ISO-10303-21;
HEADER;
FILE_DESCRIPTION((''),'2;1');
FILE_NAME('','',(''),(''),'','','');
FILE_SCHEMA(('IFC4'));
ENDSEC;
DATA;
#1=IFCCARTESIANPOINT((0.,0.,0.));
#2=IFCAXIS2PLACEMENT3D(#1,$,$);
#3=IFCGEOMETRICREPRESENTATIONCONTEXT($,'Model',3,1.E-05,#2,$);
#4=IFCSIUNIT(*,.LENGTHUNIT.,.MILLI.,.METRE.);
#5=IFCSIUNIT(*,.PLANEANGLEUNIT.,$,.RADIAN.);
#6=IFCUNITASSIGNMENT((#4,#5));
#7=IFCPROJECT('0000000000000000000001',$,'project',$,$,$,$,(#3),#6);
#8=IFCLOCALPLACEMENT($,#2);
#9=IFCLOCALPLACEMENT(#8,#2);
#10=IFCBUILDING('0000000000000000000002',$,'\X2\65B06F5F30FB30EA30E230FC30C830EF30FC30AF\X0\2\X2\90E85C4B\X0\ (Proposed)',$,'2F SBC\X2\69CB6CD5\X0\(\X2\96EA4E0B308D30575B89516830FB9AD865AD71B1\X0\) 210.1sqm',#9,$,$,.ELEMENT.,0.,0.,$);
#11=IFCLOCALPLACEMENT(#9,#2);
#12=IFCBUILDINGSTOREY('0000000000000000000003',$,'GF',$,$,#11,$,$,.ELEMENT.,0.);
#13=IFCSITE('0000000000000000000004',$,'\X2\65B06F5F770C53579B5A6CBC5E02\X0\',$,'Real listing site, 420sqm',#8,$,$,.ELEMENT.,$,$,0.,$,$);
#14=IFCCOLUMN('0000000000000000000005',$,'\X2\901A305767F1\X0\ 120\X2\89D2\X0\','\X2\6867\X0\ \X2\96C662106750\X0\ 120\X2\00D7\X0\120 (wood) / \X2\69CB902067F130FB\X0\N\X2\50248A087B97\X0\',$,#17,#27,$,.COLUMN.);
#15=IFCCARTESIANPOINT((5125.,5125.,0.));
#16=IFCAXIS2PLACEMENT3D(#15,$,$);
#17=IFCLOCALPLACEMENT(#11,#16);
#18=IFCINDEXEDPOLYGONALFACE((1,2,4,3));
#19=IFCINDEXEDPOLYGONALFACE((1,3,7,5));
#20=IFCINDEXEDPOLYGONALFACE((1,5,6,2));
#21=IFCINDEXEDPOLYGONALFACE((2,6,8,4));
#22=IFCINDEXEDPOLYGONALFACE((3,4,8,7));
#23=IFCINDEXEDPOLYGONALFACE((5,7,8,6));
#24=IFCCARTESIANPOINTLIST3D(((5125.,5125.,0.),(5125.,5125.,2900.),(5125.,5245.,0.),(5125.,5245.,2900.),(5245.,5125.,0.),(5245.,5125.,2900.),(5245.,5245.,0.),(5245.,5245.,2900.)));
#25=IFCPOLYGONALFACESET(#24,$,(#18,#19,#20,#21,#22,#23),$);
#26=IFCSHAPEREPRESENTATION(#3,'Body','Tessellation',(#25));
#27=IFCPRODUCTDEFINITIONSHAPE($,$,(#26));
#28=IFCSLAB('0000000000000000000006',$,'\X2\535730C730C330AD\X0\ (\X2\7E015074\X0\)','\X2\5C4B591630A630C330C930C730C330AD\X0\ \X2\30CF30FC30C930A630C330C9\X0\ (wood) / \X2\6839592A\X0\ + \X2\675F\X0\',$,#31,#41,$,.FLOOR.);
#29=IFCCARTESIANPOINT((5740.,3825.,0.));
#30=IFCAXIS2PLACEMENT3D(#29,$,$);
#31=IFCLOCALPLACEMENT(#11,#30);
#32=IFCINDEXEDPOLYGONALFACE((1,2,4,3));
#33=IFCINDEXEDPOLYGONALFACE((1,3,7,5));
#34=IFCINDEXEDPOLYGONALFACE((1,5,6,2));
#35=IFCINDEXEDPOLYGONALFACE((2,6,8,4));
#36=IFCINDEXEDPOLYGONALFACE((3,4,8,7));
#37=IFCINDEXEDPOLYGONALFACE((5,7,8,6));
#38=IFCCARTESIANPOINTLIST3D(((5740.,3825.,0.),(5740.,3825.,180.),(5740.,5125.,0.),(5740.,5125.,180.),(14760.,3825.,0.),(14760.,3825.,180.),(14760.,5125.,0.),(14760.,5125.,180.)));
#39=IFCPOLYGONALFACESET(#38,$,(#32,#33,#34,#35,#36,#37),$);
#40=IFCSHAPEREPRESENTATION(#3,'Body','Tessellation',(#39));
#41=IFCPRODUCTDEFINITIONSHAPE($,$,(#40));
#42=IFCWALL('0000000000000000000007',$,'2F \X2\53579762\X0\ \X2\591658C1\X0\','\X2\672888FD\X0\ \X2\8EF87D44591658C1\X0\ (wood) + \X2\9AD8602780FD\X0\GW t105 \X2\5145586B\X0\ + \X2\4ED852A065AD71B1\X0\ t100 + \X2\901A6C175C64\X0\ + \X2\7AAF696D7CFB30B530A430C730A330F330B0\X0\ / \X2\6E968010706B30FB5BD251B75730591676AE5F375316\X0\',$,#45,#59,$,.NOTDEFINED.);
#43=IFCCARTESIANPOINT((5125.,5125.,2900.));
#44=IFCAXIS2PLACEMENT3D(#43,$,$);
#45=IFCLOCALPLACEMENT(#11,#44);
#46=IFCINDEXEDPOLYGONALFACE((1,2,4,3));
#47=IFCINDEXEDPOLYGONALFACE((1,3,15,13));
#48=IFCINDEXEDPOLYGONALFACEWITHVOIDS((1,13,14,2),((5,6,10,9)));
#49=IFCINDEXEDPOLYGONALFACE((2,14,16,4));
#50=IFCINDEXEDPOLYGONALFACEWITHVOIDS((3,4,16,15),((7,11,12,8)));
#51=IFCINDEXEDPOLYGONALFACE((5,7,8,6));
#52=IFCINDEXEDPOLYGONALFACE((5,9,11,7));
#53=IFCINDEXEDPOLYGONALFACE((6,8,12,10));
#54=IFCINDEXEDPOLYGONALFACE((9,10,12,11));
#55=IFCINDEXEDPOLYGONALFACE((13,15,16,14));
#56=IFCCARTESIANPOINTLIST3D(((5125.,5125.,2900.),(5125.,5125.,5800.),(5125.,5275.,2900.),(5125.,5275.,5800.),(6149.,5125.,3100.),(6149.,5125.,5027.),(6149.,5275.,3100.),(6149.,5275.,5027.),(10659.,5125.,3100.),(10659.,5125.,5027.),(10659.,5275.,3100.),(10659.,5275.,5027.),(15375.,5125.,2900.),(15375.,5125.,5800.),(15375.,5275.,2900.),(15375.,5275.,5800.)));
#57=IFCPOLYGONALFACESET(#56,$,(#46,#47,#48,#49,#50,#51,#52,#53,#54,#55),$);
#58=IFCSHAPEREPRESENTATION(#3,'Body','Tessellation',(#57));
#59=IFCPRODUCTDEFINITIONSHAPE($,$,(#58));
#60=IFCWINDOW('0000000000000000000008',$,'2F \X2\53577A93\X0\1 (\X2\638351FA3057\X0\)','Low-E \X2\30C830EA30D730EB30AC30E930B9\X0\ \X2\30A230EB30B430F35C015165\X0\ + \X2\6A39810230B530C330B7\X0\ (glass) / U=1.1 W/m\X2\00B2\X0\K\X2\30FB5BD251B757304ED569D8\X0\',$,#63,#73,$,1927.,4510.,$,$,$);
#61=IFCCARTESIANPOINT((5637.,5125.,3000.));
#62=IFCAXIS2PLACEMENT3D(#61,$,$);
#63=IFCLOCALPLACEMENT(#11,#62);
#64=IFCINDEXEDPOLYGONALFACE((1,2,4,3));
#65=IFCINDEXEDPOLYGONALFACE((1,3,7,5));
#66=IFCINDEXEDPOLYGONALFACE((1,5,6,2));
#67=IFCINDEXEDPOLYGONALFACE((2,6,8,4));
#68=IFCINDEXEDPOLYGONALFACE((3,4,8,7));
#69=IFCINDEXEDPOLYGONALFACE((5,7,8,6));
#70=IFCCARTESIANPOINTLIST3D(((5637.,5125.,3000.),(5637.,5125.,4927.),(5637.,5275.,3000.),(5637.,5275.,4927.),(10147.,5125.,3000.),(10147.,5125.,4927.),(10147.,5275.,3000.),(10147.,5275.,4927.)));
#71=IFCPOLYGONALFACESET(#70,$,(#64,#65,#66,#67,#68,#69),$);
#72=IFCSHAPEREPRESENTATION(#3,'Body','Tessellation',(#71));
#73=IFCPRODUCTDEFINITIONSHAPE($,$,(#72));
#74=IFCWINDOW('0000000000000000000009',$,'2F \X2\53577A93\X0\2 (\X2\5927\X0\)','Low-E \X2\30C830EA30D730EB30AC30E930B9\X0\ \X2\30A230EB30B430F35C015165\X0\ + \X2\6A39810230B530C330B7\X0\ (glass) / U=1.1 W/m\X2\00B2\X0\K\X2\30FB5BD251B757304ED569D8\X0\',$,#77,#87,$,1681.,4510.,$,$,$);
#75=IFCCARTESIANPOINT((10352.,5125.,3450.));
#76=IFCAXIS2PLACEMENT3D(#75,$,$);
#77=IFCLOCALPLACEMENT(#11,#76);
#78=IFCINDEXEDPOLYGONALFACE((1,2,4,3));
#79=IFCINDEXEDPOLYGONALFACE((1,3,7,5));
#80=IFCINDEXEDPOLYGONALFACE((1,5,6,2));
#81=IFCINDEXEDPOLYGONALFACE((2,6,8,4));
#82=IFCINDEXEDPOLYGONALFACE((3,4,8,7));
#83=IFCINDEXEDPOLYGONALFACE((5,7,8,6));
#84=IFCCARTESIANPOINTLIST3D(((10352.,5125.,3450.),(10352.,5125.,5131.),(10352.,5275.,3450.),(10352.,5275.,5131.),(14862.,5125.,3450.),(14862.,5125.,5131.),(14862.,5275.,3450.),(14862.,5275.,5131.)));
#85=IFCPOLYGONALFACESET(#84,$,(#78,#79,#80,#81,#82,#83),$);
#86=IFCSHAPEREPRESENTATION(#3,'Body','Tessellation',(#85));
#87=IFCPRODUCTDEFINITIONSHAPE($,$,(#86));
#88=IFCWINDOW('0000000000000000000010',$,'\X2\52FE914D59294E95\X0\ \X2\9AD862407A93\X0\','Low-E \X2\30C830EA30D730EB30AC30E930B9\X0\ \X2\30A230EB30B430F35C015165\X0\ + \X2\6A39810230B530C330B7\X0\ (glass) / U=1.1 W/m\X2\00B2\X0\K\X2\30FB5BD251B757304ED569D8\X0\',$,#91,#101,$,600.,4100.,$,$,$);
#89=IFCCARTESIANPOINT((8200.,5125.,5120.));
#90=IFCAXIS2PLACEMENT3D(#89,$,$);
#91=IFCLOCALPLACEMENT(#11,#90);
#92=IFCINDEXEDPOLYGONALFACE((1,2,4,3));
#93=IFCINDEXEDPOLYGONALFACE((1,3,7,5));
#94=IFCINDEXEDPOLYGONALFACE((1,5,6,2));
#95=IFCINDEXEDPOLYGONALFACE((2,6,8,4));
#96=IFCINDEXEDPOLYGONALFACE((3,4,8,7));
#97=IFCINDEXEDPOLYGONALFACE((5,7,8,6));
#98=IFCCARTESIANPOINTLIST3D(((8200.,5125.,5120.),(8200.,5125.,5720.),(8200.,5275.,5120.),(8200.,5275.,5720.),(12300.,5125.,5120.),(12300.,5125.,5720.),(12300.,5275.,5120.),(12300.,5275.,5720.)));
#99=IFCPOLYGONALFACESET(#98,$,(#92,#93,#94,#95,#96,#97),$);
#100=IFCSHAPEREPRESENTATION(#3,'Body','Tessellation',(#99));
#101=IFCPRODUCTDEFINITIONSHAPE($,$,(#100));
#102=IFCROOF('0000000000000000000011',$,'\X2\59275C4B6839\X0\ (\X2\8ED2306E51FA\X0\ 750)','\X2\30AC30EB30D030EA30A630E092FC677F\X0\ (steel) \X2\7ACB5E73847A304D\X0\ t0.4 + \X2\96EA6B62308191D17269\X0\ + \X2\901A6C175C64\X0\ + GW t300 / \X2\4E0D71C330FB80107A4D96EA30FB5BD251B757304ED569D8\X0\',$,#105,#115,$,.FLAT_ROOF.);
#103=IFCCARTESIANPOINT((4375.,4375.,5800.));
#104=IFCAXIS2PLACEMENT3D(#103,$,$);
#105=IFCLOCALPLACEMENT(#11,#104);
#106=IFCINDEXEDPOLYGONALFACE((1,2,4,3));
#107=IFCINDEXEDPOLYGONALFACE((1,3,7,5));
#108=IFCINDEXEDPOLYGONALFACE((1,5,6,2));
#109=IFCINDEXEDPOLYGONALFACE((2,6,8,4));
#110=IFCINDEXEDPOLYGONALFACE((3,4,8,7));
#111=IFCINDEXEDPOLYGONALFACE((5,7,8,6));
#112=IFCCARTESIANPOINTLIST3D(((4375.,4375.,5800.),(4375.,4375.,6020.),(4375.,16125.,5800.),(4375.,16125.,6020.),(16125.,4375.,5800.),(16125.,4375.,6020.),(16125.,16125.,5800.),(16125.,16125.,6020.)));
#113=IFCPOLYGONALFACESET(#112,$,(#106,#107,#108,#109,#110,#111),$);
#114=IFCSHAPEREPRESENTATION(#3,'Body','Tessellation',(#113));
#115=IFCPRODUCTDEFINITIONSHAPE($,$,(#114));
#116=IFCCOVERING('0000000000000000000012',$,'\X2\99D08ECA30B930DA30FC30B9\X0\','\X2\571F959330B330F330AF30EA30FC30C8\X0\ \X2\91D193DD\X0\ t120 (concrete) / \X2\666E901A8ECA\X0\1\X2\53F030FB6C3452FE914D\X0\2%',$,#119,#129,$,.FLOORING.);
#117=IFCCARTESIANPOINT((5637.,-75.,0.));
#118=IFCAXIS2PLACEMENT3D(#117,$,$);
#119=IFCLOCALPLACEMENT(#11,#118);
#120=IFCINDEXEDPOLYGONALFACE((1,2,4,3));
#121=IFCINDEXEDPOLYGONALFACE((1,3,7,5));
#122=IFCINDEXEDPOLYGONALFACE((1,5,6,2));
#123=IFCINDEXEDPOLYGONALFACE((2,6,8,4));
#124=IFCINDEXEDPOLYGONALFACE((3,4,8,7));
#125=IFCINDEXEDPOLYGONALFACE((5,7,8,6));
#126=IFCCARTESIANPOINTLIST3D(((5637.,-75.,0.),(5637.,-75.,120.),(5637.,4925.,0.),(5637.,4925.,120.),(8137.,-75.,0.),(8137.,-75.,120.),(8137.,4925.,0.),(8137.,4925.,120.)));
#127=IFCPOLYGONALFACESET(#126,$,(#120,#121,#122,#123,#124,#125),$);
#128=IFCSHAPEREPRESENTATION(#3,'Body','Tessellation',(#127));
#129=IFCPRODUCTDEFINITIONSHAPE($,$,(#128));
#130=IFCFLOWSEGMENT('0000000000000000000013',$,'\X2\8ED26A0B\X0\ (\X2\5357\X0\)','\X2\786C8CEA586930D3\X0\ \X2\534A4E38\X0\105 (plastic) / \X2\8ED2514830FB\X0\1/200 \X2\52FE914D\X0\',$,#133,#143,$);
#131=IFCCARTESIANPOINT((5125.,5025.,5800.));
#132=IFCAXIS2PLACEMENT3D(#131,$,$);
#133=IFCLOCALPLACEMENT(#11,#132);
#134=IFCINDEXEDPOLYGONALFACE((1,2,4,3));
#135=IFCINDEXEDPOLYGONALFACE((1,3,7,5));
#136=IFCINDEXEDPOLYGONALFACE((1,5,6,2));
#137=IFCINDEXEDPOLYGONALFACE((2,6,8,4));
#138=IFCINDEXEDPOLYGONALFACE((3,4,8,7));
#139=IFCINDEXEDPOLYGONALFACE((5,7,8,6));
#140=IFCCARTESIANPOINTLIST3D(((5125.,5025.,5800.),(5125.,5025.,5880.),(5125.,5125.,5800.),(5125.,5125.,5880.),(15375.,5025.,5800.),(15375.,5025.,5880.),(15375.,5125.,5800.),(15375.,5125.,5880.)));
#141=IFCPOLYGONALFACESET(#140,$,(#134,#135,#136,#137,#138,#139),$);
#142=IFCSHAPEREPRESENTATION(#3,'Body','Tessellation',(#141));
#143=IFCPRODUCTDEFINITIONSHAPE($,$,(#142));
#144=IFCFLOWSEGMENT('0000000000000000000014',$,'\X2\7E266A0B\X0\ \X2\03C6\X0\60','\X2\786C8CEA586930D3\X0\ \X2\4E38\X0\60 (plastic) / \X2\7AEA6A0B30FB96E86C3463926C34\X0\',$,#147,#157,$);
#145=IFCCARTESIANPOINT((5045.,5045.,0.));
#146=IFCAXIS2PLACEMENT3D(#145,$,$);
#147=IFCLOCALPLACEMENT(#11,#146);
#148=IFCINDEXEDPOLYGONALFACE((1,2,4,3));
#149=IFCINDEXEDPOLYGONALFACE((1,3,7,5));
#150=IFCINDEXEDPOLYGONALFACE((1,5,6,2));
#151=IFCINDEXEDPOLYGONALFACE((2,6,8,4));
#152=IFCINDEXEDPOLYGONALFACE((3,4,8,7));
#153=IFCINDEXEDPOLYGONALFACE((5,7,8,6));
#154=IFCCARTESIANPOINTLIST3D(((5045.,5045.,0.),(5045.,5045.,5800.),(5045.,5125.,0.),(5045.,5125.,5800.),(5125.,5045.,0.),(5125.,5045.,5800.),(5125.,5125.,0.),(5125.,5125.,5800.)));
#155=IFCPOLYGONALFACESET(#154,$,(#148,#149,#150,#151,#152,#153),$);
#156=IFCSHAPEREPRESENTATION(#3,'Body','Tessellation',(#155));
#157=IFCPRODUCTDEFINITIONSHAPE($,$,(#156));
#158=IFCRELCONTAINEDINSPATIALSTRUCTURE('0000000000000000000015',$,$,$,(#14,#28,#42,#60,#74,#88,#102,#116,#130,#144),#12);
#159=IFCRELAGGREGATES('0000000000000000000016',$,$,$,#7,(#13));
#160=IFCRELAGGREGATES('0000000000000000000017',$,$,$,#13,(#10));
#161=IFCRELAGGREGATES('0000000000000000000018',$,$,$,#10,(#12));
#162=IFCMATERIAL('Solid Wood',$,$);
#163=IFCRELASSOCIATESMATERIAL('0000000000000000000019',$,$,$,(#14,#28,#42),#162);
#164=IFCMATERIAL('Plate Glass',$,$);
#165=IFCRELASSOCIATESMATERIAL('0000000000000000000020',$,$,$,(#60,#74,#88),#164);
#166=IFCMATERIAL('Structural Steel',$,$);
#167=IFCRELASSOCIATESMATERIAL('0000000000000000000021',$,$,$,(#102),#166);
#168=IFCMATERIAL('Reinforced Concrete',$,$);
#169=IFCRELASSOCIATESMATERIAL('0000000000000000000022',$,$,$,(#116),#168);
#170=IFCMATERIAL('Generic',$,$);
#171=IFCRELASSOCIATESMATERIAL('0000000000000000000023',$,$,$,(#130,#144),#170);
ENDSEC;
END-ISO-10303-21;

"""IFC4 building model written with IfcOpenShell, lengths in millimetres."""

from ifc_helpers import new_model, si_unit, frame, frame_2d, origin, place, context, project, spatial, rectangle, extrude, material, element, fill, save


model = new_model("IFC4")

# Units and contexts
model_context = context("Model", 3, precision=1e-05, world=origin())
ifc_project = project(units=[si_unit("LENGTHUNIT", "METRE", prefix="MILLI"), si_unit("PLANEANGLEUNIT", "RADIAN")], contexts=[model_context])

# Site, building, storey
site_placement = place(None, origin())
site = spatial("IfcSite", under=ifc_project, at=site_placement, Name="新潟県南魚沼市", ObjectType="Real listing site, 420sqm", CompositionType="ELEMENT", RefElevation=0.0)
building_placement = place(site_placement, origin())
building = spatial("IfcBuilding", under=site, at=building_placement, Name="新潟・リモートワーク2部屋 (Proposed)", ObjectType="2F SBC構法(雪下ろし安全・高断熱) 210.1sqm", CompositionType="ELEMENT", ElevationOfRefHeight=0.0, ElevationOfTerrain=0.0)
storey_placement = place(building_placement, origin())
storey = spatial("IfcBuildingStorey", under=building, at=storey_placement, Name="GF", CompositionType="ELEMENT", Elevation=0.0)

# Column
ifc_material_1 = material(Name="Solid Wood")
column_placement = place(storey_placement, frame((5125.0, 5125.0, 0.0)))
element("IfcColumn", 1, at=column_placement, inside=storey, material=ifc_material_1, Name="通し柱 120角", Description="桧 集成材 120×120 (wood) / 構造柱・N値計算", PredefinedType="COLUMN", context=model_context, shape_type="SweptSolid", body=[
    extrude(rectangle(XDim=120.0, YDim=120.0, at=frame_2d((60.0, 60.0))), frame((5125.0, 5125.0, 0.0)), (0.0, 0.0, 1.0), 2900.0),
])

# Slab
ifc_material_2 = material(Name="Reinforced Concrete")
slab_1_placement = place(storey_placement, frame((5740.0, 3825.0, 0.0)))
element("IfcSlab", 2, at=slab_1_placement, inside=storey, material=ifc_material_1, Name="南デッキ (縁側)", Description="屋外ウッドデッキ ハードウッド (wood) / 根太 + 束", PredefinedType="FLOOR", context=model_context, shape_type="SweptSolid", body=[
    extrude(rectangle(XDim=9020.0, YDim=1300.0, at=frame_2d((4510.0, 650.0))), frame((5740.0, 3825.0, 0.0)), (0.0, 0.0, 1.0), 180.0),
])

# Shared definitions
ifc_material_3 = material(Name="Plate Glass")

# Wall, openings, windows
wall_1_placement = place(storey_placement, frame((5125.0, 5125.0, 2900.0)))
wall_1 = element("IfcWall", 3, at=wall_1_placement, inside=storey, material=ifc_material_1, Name="2F 南面 外壁", Description="木製 軸組外壁 (wood) + 高性能GW t105 充填 + 付加断熱 t100 + 通気層 + 窯業系サイディング / 準耐火・寒冷地外皮強化", PredefinedType="NOTDEFINED", context=model_context, shape_type="SweptSolid", body=[
    extrude(rectangle(XDim=10250.0, YDim=150.0, at=frame_2d((5125.0, 75.0))), frame((5125.0, 5125.0, 2900.0)), (0.0, 0.0, 1.0), 2900.0),
])
opening_1_placement = place(storey_placement, frame((5637.0, 5125.0, 3000.0)))
opening_1 = element("IfcOpeningElement", 4, at=opening_1_placement, cuts=wall_1, PredefinedType="NOTDEFINED", context=model_context, shape_type="SweptSolid", body=[
    extrude(rectangle(XDim=4510.0, YDim=150.0, at=frame_2d((2255.0, 75.0))), frame((5637.0, 5125.0, 3000.0)), (0.0, 0.0, 1.0), 1927.0),
])
opening_2_placement = place(storey_placement, frame((10352.0, 5125.0, 3450.0)))
opening_2 = element("IfcOpeningElement", 5, at=opening_2_placement, cuts=wall_1, PredefinedType="NOTDEFINED", context=model_context, shape_type="SweptSolid", body=[
    extrude(rectangle(XDim=4510.0, YDim=150.0, at=frame_2d((2255.0, 75.0))), frame((10352.0, 5125.0, 3450.0)), (0.0, 0.0, 1.0), 1681.0),
])
opening_3_placement = place(storey_placement, frame((8200.0, 5125.0, 5120.0)))
opening_3 = element("IfcOpeningElement", 6, at=opening_3_placement, cuts=wall_1, PredefinedType="NOTDEFINED", context=model_context, shape_type="SweptSolid", body=[
    extrude(rectangle(XDim=4100.0, YDim=150.0, at=frame_2d((2050.0, 75.0))), frame((8200.0, 5125.0, 5120.0)), (0.0, 0.0, 1.0), 600.0),
])
window_1_placement = place(storey_placement, frame((5637.0, 5125.0, 3000.0)))
window_1 = element("IfcWindow", 7, at=window_1_placement, inside=storey, material=ifc_material_3, Name="2F 南窓1 (掃出し)", Description="Low-E トリプルガラス アルゴン封入 + 樹脂サッシ (glass) / U=1.1 W/m²K・寒冷地仕様", OverallHeight=1927.0, OverallWidth=4510.0, context=model_context, shape_type="SweptSolid", body=[
    extrude(rectangle(XDim=4510.0, YDim=150.0, at=frame_2d((2255.0, 75.0))), frame((5637.0, 5125.0, 3000.0)), (0.0, 0.0, 1.0), 1927.0),
])
fill(opening_1, window_1)
window_2_placement = place(storey_placement, frame((10352.0, 5125.0, 3450.0)))
window_2 = element("IfcWindow", 8, at=window_2_placement, inside=storey, material=ifc_material_3, Name="2F 南窓2 (大)", Description="Low-E トリプルガラス アルゴン封入 + 樹脂サッシ (glass) / U=1.1 W/m²K・寒冷地仕様", OverallHeight=1681.0, OverallWidth=4510.0, context=model_context, shape_type="SweptSolid", body=[
    extrude(rectangle(XDim=4510.0, YDim=150.0, at=frame_2d((2255.0, 75.0))), frame((10352.0, 5125.0, 3450.0)), (0.0, 0.0, 1.0), 1681.0),
])
fill(opening_2, window_2)
window_3_placement = place(storey_placement, frame((8200.0, 5125.0, 5120.0)))
window_3 = element("IfcWindow", 9, at=window_3_placement, inside=storey, material=ifc_material_3, Name="勾配天井 高所窓", Description="Low-E トリプルガラス アルゴン封入 + 樹脂サッシ (glass) / U=1.1 W/m²K・寒冷地仕様", OverallHeight=600.0, OverallWidth=4100.0, context=model_context, shape_type="SweptSolid", body=[
    extrude(rectangle(XDim=4100.0, YDim=150.0, at=frame_2d((2050.0, 75.0))), frame((8200.0, 5125.0, 5120.0)), (0.0, 0.0, 1.0), 600.0),
])
fill(opening_3, window_3)

# Roof
ifc_material_4 = material(Name="Structural Steel")
roof_placement = place(storey_placement, frame((4375.0, 4375.0, 5800.0)))
element("IfcRoof", 10, at=roof_placement, inside=storey, material=ifc_material_4, Name="大屋根 (軒の出 750)", Description="ガルバリウム鋼板 (steel) 立平葺き t0.4 + 雪止め金物 + 通気層 + GW t300 / 不燃・耐積雪・寒冷地仕様", PredefinedType="FLAT_ROOF", context=model_context, shape_type="SweptSolid", body=[
    extrude(rectangle(XDim=11750.0, YDim=11750.0, at=frame_2d((5875.0, 5875.0))), frame((4375.0, 4375.0, 5800.0)), (0.0, 0.0, 1.0), 220.0),
])

# Covering
covering_placement = place(storey_placement, frame((5637.0, -75.0, 0.0)))
element("IfcCovering", 11, at=covering_placement, inside=storey, material=ifc_material_2, Name="駐車スペース", Description="土間コンクリート 金鏝 t120 (concrete) / 普通車1台・水勾配2%", PredefinedType="FLOORING", context=model_context, shape_type="SweptSolid", body=[
    extrude(rectangle(XDim=2500.0, YDim=5000.0, at=frame_2d((1250.0, 2500.0))), frame((5637.0, -75.0, 0.0)), (0.0, 0.0, 1.0), 120.0),
])

# Flow segments
ifc_material_5 = material(Name="Generic")
flow_segment_1_placement = place(storey_placement, frame((5125.0, 5025.0, 5800.0)))
element("IfcFlowSegment", 12, at=flow_segment_1_placement, inside=storey, material=ifc_material_5, Name="軒樋 (南)", Description="硬質塩ビ 半丸105 (plastic) / 軒先・1/200 勾配", context=model_context, shape_type="SweptSolid", body=[
    extrude(rectangle(XDim=10250.0, YDim=100.0, at=frame_2d((5125.0, 50.0))), frame((5125.0, 5025.0, 5800.0)), (0.0, 0.0, 1.0), 80.0),
])
flow_segment_2_placement = place(storey_placement, frame((5045.0, 5045.0, 0.0)))
element("IfcFlowSegment", 13, at=flow_segment_2_placement, inside=storey, material=ifc_material_5, Name="縦樋 φ60", Description="硬質塩ビ 丸60 (plastic) / 竪樋・雨水排水", context=model_context, shape_type="SweptSolid", body=[
    extrude(rectangle(XDim=80.0, YDim=80.0, at=frame_2d((40.0, 40.0))), frame((5045.0, 5045.0, 0.0)), (0.0, 0.0, 1.0), 5800.0),
])

save(model, "model.ifc")
